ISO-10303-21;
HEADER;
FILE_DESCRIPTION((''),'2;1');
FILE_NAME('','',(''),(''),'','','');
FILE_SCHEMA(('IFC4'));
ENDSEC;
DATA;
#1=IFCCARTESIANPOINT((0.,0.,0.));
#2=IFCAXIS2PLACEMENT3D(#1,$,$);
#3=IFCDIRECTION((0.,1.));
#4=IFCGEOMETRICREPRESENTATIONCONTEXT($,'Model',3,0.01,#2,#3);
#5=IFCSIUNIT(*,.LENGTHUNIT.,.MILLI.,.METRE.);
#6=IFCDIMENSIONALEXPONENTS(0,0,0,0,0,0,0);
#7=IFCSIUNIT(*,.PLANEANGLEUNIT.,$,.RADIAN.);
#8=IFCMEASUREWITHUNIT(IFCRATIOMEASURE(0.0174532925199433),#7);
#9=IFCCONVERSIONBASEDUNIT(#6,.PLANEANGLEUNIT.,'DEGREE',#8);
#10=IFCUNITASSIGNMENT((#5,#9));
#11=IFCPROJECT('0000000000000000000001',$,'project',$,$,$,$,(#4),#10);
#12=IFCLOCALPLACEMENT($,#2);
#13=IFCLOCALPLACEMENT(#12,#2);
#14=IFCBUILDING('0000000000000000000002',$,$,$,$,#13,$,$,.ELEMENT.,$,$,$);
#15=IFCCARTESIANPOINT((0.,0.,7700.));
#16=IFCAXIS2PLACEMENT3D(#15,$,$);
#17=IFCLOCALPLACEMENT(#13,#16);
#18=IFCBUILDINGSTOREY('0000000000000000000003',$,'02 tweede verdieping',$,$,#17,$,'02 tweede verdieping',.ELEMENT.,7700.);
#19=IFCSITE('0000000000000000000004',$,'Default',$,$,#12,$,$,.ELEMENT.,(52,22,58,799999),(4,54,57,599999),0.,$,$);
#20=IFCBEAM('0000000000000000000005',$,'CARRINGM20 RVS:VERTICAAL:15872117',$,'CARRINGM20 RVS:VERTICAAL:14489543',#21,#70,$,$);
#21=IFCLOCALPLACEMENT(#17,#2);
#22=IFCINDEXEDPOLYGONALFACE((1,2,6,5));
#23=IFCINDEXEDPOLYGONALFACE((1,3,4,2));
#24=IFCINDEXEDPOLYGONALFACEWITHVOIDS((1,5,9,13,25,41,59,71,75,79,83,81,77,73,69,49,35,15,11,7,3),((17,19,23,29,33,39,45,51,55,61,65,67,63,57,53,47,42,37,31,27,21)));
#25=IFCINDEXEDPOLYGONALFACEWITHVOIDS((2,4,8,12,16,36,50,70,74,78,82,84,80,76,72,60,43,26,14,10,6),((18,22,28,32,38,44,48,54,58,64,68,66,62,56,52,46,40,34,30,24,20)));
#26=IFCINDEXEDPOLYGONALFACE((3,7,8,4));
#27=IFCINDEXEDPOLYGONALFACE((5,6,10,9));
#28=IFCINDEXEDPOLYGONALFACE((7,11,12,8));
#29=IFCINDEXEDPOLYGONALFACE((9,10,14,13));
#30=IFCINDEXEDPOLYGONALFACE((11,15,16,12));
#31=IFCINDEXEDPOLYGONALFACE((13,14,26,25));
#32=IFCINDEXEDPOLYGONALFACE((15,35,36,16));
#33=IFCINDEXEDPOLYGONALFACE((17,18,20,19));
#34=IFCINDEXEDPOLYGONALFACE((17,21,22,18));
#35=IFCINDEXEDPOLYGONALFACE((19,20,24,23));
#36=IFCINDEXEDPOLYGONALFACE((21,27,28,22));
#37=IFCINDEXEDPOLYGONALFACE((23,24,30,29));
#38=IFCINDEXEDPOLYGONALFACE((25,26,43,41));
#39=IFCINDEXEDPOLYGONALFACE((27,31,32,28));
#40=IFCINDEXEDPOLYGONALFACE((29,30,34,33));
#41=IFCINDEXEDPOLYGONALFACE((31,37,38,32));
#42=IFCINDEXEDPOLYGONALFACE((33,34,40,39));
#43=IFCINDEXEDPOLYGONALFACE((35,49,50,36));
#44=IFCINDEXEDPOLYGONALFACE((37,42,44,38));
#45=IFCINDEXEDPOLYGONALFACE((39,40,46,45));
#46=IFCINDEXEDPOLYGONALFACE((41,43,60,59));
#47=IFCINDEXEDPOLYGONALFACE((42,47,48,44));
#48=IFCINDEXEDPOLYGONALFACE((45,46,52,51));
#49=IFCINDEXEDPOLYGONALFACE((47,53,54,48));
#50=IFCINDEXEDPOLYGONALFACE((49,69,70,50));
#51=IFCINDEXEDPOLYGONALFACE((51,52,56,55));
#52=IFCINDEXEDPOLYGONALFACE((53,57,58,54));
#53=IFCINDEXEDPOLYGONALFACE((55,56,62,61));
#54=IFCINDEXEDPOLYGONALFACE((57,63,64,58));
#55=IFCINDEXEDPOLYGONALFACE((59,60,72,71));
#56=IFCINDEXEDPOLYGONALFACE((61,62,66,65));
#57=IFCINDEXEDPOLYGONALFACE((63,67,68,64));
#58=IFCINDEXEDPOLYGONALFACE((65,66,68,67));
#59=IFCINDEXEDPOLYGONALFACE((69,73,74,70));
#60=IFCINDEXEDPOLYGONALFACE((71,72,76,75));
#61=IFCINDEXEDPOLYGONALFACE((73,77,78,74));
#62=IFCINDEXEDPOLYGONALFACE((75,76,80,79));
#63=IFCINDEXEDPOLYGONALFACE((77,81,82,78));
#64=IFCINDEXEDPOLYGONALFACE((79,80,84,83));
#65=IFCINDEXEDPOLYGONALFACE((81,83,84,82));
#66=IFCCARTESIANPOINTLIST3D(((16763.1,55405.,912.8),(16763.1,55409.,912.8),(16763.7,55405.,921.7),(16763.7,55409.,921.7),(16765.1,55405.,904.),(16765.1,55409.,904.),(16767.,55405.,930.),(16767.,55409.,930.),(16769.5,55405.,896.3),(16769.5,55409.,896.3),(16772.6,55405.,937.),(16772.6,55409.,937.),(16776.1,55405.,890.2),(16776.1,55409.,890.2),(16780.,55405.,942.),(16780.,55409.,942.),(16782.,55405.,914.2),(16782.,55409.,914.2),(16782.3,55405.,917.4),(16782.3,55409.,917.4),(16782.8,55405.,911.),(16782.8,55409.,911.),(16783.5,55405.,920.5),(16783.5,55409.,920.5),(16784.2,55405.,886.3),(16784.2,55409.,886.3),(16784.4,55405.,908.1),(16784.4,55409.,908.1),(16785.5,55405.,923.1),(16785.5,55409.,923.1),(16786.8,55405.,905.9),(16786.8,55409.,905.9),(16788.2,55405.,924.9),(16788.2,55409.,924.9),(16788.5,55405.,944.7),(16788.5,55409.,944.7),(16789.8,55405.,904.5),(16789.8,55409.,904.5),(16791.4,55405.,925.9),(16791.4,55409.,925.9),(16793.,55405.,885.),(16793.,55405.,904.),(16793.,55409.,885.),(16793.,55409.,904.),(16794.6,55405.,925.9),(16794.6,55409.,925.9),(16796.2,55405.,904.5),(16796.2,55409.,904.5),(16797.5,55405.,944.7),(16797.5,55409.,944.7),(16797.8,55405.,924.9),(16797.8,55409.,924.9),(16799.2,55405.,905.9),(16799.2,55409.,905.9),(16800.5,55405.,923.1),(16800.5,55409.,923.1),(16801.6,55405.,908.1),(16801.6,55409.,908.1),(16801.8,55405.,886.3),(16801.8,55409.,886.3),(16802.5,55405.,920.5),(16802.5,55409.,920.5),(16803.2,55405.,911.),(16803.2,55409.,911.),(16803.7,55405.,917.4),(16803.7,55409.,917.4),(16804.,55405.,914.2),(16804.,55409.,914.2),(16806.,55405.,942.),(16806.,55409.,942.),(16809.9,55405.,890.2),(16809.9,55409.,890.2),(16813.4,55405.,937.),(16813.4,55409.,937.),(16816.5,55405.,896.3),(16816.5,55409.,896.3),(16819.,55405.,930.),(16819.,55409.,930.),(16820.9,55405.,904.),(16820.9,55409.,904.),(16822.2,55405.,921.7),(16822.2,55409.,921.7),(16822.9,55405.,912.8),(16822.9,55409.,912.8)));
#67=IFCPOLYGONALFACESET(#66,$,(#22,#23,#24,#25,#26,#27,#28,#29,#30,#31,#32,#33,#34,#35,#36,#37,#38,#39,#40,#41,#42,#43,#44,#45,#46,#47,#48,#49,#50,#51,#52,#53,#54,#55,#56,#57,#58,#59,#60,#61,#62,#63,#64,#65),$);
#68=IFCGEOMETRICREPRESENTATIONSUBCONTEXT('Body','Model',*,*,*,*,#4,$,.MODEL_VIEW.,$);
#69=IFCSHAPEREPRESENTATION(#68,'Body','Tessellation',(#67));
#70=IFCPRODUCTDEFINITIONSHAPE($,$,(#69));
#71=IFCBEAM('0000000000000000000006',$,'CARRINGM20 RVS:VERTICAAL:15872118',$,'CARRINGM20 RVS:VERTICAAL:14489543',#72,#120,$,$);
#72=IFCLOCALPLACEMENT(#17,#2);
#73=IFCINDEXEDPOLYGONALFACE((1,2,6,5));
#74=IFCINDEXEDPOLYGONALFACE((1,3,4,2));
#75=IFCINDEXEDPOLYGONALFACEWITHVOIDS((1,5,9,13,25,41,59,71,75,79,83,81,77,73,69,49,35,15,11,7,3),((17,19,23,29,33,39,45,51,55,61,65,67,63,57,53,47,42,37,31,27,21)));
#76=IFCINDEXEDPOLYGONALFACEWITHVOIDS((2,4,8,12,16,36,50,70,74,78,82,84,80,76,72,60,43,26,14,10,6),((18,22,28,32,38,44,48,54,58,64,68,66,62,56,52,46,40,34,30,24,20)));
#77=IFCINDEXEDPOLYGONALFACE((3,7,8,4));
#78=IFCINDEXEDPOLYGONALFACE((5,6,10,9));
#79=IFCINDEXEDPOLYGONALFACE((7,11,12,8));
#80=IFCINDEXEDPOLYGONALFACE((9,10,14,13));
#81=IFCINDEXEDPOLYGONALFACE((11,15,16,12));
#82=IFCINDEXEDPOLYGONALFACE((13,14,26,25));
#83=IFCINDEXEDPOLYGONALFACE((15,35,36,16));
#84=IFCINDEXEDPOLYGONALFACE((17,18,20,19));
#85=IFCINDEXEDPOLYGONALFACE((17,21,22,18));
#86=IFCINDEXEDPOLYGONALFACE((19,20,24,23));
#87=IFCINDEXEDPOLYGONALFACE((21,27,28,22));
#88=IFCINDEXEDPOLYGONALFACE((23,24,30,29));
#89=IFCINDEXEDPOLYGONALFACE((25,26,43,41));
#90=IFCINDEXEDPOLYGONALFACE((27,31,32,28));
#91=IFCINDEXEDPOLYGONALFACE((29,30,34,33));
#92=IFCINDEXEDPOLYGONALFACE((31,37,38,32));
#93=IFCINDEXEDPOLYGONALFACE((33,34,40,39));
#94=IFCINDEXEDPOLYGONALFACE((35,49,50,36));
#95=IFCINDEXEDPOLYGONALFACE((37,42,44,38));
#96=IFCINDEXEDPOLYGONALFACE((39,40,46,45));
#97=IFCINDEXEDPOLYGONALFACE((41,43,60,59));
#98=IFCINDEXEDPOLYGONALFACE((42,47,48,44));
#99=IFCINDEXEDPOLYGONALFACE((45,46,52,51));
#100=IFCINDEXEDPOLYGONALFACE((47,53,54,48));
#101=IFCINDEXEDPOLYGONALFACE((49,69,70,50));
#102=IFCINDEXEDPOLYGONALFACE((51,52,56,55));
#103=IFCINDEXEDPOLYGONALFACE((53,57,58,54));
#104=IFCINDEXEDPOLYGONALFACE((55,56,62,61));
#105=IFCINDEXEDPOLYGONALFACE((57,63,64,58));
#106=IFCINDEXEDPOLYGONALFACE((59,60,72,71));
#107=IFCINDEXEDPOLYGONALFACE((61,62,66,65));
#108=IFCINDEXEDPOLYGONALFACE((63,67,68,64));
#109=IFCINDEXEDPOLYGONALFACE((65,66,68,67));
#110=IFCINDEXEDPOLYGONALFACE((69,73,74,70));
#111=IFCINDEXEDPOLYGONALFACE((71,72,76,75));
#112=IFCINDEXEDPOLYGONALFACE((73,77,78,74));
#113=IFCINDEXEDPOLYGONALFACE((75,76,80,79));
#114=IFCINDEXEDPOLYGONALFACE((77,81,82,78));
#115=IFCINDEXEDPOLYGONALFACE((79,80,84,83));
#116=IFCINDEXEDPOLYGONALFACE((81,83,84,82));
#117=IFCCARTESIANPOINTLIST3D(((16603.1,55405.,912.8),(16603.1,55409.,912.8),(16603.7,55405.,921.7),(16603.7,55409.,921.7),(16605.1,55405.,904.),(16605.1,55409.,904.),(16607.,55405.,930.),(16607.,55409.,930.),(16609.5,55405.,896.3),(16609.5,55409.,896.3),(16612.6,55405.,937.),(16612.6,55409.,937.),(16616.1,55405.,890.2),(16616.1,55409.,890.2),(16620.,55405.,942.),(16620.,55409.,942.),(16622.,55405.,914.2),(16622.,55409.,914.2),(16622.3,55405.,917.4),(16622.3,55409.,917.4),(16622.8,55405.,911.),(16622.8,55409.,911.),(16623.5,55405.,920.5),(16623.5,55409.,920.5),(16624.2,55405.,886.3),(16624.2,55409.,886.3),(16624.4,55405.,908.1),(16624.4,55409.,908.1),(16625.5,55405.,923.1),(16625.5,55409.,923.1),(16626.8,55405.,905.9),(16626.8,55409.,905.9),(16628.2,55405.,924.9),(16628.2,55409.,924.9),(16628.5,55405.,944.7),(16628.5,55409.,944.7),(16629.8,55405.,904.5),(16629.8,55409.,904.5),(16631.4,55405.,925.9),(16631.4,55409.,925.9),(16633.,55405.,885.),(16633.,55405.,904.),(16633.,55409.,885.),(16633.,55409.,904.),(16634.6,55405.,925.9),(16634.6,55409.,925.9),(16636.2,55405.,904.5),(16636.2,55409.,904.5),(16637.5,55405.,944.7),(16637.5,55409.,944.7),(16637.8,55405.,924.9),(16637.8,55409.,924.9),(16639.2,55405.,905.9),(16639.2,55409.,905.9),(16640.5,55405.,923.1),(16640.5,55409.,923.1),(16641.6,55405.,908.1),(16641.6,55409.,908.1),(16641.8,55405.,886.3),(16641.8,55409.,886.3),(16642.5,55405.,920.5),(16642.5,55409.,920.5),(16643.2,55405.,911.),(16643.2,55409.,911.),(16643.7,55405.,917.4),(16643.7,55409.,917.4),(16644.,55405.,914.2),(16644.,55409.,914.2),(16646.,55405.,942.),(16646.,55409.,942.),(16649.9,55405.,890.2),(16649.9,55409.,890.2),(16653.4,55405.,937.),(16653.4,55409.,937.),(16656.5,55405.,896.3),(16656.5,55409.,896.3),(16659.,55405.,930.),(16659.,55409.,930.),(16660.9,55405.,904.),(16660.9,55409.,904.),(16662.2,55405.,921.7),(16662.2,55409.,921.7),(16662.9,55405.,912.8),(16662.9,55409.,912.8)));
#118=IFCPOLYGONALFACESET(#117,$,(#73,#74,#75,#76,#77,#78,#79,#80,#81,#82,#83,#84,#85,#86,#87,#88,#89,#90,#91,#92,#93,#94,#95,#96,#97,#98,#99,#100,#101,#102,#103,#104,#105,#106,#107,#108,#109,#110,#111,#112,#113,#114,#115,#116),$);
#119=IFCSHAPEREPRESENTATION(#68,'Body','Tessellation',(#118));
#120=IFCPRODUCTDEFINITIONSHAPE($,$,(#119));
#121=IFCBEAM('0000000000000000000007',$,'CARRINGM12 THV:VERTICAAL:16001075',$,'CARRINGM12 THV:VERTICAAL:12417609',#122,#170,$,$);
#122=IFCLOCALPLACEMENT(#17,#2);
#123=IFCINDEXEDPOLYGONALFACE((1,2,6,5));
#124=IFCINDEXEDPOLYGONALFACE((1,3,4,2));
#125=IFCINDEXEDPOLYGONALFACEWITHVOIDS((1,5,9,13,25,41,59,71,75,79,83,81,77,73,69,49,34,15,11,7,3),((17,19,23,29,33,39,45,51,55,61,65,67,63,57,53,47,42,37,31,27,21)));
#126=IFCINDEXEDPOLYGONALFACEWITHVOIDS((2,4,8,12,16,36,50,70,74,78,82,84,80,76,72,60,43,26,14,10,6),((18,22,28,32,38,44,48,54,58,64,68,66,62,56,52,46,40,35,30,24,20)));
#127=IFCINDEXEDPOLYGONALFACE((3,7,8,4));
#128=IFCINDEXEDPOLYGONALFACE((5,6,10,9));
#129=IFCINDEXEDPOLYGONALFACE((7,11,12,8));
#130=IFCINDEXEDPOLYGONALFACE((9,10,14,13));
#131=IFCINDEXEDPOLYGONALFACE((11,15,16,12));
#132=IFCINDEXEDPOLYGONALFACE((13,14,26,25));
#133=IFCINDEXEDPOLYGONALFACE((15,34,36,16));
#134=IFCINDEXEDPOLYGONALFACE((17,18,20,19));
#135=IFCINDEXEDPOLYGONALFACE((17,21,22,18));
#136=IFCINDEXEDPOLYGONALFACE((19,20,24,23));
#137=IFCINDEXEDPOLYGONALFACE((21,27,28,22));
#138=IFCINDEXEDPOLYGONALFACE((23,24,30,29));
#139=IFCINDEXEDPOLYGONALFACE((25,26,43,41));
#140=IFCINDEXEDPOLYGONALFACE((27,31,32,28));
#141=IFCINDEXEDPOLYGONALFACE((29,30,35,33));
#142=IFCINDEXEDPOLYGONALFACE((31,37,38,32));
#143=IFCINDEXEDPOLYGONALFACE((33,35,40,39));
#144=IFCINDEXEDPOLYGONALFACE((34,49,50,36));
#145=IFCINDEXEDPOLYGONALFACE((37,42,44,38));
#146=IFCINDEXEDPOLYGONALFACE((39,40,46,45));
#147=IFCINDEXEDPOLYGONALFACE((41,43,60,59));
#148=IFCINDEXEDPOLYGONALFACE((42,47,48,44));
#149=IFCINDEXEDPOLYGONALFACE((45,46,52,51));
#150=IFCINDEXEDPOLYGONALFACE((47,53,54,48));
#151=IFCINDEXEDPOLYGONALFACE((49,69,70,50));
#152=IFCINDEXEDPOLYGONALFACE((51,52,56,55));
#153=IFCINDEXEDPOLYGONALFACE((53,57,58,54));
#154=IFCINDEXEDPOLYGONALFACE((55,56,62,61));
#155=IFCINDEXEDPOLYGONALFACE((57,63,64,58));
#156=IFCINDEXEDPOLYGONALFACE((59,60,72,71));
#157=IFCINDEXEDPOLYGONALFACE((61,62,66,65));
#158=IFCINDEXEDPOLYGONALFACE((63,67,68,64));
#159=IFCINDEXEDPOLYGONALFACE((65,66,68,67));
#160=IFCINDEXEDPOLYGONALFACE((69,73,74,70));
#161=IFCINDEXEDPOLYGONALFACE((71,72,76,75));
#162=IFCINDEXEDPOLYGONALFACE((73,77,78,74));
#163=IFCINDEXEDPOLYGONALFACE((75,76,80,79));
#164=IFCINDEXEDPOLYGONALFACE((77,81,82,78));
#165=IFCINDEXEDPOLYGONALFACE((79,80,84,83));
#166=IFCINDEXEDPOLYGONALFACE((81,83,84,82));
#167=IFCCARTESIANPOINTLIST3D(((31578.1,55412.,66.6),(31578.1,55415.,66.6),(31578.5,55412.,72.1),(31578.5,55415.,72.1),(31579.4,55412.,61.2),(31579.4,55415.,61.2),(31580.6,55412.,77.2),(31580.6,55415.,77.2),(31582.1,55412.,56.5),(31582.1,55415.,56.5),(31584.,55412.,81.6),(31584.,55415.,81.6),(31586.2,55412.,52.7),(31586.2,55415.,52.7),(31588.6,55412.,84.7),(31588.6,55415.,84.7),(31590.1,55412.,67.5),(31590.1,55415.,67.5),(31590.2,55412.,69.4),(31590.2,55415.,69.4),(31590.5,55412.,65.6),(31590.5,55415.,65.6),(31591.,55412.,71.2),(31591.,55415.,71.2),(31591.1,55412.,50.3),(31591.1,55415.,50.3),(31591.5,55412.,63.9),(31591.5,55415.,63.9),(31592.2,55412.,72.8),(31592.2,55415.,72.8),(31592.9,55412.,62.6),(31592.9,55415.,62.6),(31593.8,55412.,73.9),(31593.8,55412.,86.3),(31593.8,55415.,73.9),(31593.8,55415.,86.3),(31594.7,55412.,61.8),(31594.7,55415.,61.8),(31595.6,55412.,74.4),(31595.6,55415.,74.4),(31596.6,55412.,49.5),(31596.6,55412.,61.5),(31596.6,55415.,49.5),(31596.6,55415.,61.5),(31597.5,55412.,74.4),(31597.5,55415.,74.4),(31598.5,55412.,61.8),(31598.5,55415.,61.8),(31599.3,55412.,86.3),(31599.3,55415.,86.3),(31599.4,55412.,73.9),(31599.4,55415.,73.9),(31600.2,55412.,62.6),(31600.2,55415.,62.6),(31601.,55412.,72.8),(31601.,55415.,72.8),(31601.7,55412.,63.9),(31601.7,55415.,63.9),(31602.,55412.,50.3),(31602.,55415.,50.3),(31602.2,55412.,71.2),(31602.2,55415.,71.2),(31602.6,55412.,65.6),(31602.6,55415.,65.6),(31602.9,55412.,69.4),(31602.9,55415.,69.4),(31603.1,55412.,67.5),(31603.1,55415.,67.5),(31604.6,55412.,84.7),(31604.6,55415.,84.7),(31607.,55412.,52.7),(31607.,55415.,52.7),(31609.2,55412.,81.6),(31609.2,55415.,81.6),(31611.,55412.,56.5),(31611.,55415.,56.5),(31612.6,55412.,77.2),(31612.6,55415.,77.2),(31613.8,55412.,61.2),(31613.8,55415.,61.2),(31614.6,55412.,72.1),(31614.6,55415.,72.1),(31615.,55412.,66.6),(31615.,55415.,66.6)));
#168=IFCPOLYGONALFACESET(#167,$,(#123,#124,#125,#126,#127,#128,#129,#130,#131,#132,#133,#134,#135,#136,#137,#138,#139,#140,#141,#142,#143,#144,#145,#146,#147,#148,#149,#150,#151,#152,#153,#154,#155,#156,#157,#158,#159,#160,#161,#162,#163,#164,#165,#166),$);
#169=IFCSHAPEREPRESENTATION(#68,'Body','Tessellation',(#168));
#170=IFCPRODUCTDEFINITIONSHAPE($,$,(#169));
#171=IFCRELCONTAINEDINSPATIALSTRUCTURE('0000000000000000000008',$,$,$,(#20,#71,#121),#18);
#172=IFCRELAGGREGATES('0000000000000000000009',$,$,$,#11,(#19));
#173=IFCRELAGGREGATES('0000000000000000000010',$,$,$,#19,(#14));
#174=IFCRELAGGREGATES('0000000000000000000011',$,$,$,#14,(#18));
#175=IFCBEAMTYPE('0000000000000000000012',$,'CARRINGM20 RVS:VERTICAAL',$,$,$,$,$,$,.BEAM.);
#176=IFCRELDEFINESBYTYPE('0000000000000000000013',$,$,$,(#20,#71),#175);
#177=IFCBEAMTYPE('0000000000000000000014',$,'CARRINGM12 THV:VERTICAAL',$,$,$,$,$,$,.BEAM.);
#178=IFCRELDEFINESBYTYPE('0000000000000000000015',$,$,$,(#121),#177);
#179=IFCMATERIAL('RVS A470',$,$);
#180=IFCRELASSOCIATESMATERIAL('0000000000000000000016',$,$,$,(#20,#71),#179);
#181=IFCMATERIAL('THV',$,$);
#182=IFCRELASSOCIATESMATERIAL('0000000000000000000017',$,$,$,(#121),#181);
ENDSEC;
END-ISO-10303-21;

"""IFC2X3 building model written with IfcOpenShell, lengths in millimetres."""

from ifc_helpers import new_model, entity, si_unit, converted_unit, direction, frame, origin, origin_2d_with_axis, place, context, subcontext, project, spatial, hollow_circle, extrude, material, type_object, element, save


model = new_model("IFC2X3")

# Units and contexts
model_context = context("Model", 3, precision=0.01, world=origin(), true_north=direction((0.0, 1.0)))
body_context = subcontext(model_context, "Body", "Model", "MODEL_VIEW")
ifc_project = project(units=[si_unit("LENGTHUNIT", "METRE", prefix="MILLI"), converted_unit("PLANEANGLEUNIT", "DEGREE", entity("IfcRatioMeasure", 0.0174532925199433), si_unit("PLANEANGLEUNIT", "RADIAN"), dimensions=[0, 0, 0, 0, 0, 0, 0])], contexts=[model_context])

# Site, building, storey
site_placement = place(None, origin())
site = spatial("IfcSite", under=ifc_project, at=site_placement, Name="Default", CompositionType="ELEMENT", RefLatitude=(52, 22, 58, 799999), RefLongitude=(4, 54, 57, 599999), RefElevation=0.0)
building_placement = place(site_placement, origin())
building = spatial("IfcBuilding", under=site, at=building_placement, CompositionType="ELEMENT")
storey_placement = place(building_placement, frame((0.0, 0.0, 7700.0)))
storey = spatial("IfcBuildingStorey", under=building, at=storey_placement, Name="02 tweede verdieping", LongName="02 tweede verdieping", CompositionType="ELEMENT", Elevation=7700.0)

# Beams
ifc_material_1 = material(Name="RVS A470")
beam_type_1 = type_object("IfcBeamType", Name="CARRINGM20 RVS:VERTICAAL", PredefinedType="BEAM")
beam_1_placement = place(storey_placement, origin())
element("IfcBeam", 1, at=beam_1_placement, inside=storey, type_object=beam_type_1, material=ifc_material_1, Name="CARRINGM20 RVS:VERTICAAL:15872117", ObjectType="CARRINGM20 RVS:VERTICAAL:14489543", context=body_context, shape_type="SweptSolid", body=[
    extrude(hollow_circle(Radius=30.0, WallThickness=19.0, at=origin_2d_with_axis()), frame((16793.0, 55405.0, 915.0), z_axis=(0.0, 1.0, 0.0), x_axis=(0.0, 0.0, -1.0)), (0.0, 0.0, 1.0), 4.0),
])
beam_2_placement = place(storey_placement, origin())
element("IfcBeam", 2, at=beam_2_placement, inside=storey, type_object=beam_type_1, material=ifc_material_1, Name="CARRINGM20 RVS:VERTICAAL:15872118", ObjectType="CARRINGM20 RVS:VERTICAAL:14489543", context=body_context, shape_type="SweptSolid", body=[
    extrude(hollow_circle(Radius=30.0, WallThickness=19.0, at=origin_2d_with_axis()), frame((16633.0, 55405.0, 915.0), z_axis=(0.0, 1.0, 0.0), x_axis=(0.0, 0.0, -1.0)), (0.0, 0.0, 1.0), 4.0),
])
ifc_material_2 = material(Name="THV")
beam_type_2 = type_object("IfcBeamType", Name="CARRINGM12 THV:VERTICAAL", PredefinedType="BEAM")
beam_3_placement = place(storey_placement, origin())
element("IfcBeam", 3, at=beam_3_placement, inside=storey, type_object=beam_type_2, material=ifc_material_2, Name="CARRINGM12 THV:VERTICAAL:16001075", ObjectType="CARRINGM12 THV:VERTICAAL:12417609", context=body_context, shape_type="SweptSolid", body=[
    extrude(hollow_circle(Radius=18.5, WallThickness=12.0, at=origin_2d_with_axis()), frame((31596.6, 55412.0, 68.0), z_axis=(0.0, 1.0, 0.0), x_axis=(0.0, 0.0, -1.0)), (0.0, 0.0, 1.0), 3.0),
])

save(model, "model.ifc")
